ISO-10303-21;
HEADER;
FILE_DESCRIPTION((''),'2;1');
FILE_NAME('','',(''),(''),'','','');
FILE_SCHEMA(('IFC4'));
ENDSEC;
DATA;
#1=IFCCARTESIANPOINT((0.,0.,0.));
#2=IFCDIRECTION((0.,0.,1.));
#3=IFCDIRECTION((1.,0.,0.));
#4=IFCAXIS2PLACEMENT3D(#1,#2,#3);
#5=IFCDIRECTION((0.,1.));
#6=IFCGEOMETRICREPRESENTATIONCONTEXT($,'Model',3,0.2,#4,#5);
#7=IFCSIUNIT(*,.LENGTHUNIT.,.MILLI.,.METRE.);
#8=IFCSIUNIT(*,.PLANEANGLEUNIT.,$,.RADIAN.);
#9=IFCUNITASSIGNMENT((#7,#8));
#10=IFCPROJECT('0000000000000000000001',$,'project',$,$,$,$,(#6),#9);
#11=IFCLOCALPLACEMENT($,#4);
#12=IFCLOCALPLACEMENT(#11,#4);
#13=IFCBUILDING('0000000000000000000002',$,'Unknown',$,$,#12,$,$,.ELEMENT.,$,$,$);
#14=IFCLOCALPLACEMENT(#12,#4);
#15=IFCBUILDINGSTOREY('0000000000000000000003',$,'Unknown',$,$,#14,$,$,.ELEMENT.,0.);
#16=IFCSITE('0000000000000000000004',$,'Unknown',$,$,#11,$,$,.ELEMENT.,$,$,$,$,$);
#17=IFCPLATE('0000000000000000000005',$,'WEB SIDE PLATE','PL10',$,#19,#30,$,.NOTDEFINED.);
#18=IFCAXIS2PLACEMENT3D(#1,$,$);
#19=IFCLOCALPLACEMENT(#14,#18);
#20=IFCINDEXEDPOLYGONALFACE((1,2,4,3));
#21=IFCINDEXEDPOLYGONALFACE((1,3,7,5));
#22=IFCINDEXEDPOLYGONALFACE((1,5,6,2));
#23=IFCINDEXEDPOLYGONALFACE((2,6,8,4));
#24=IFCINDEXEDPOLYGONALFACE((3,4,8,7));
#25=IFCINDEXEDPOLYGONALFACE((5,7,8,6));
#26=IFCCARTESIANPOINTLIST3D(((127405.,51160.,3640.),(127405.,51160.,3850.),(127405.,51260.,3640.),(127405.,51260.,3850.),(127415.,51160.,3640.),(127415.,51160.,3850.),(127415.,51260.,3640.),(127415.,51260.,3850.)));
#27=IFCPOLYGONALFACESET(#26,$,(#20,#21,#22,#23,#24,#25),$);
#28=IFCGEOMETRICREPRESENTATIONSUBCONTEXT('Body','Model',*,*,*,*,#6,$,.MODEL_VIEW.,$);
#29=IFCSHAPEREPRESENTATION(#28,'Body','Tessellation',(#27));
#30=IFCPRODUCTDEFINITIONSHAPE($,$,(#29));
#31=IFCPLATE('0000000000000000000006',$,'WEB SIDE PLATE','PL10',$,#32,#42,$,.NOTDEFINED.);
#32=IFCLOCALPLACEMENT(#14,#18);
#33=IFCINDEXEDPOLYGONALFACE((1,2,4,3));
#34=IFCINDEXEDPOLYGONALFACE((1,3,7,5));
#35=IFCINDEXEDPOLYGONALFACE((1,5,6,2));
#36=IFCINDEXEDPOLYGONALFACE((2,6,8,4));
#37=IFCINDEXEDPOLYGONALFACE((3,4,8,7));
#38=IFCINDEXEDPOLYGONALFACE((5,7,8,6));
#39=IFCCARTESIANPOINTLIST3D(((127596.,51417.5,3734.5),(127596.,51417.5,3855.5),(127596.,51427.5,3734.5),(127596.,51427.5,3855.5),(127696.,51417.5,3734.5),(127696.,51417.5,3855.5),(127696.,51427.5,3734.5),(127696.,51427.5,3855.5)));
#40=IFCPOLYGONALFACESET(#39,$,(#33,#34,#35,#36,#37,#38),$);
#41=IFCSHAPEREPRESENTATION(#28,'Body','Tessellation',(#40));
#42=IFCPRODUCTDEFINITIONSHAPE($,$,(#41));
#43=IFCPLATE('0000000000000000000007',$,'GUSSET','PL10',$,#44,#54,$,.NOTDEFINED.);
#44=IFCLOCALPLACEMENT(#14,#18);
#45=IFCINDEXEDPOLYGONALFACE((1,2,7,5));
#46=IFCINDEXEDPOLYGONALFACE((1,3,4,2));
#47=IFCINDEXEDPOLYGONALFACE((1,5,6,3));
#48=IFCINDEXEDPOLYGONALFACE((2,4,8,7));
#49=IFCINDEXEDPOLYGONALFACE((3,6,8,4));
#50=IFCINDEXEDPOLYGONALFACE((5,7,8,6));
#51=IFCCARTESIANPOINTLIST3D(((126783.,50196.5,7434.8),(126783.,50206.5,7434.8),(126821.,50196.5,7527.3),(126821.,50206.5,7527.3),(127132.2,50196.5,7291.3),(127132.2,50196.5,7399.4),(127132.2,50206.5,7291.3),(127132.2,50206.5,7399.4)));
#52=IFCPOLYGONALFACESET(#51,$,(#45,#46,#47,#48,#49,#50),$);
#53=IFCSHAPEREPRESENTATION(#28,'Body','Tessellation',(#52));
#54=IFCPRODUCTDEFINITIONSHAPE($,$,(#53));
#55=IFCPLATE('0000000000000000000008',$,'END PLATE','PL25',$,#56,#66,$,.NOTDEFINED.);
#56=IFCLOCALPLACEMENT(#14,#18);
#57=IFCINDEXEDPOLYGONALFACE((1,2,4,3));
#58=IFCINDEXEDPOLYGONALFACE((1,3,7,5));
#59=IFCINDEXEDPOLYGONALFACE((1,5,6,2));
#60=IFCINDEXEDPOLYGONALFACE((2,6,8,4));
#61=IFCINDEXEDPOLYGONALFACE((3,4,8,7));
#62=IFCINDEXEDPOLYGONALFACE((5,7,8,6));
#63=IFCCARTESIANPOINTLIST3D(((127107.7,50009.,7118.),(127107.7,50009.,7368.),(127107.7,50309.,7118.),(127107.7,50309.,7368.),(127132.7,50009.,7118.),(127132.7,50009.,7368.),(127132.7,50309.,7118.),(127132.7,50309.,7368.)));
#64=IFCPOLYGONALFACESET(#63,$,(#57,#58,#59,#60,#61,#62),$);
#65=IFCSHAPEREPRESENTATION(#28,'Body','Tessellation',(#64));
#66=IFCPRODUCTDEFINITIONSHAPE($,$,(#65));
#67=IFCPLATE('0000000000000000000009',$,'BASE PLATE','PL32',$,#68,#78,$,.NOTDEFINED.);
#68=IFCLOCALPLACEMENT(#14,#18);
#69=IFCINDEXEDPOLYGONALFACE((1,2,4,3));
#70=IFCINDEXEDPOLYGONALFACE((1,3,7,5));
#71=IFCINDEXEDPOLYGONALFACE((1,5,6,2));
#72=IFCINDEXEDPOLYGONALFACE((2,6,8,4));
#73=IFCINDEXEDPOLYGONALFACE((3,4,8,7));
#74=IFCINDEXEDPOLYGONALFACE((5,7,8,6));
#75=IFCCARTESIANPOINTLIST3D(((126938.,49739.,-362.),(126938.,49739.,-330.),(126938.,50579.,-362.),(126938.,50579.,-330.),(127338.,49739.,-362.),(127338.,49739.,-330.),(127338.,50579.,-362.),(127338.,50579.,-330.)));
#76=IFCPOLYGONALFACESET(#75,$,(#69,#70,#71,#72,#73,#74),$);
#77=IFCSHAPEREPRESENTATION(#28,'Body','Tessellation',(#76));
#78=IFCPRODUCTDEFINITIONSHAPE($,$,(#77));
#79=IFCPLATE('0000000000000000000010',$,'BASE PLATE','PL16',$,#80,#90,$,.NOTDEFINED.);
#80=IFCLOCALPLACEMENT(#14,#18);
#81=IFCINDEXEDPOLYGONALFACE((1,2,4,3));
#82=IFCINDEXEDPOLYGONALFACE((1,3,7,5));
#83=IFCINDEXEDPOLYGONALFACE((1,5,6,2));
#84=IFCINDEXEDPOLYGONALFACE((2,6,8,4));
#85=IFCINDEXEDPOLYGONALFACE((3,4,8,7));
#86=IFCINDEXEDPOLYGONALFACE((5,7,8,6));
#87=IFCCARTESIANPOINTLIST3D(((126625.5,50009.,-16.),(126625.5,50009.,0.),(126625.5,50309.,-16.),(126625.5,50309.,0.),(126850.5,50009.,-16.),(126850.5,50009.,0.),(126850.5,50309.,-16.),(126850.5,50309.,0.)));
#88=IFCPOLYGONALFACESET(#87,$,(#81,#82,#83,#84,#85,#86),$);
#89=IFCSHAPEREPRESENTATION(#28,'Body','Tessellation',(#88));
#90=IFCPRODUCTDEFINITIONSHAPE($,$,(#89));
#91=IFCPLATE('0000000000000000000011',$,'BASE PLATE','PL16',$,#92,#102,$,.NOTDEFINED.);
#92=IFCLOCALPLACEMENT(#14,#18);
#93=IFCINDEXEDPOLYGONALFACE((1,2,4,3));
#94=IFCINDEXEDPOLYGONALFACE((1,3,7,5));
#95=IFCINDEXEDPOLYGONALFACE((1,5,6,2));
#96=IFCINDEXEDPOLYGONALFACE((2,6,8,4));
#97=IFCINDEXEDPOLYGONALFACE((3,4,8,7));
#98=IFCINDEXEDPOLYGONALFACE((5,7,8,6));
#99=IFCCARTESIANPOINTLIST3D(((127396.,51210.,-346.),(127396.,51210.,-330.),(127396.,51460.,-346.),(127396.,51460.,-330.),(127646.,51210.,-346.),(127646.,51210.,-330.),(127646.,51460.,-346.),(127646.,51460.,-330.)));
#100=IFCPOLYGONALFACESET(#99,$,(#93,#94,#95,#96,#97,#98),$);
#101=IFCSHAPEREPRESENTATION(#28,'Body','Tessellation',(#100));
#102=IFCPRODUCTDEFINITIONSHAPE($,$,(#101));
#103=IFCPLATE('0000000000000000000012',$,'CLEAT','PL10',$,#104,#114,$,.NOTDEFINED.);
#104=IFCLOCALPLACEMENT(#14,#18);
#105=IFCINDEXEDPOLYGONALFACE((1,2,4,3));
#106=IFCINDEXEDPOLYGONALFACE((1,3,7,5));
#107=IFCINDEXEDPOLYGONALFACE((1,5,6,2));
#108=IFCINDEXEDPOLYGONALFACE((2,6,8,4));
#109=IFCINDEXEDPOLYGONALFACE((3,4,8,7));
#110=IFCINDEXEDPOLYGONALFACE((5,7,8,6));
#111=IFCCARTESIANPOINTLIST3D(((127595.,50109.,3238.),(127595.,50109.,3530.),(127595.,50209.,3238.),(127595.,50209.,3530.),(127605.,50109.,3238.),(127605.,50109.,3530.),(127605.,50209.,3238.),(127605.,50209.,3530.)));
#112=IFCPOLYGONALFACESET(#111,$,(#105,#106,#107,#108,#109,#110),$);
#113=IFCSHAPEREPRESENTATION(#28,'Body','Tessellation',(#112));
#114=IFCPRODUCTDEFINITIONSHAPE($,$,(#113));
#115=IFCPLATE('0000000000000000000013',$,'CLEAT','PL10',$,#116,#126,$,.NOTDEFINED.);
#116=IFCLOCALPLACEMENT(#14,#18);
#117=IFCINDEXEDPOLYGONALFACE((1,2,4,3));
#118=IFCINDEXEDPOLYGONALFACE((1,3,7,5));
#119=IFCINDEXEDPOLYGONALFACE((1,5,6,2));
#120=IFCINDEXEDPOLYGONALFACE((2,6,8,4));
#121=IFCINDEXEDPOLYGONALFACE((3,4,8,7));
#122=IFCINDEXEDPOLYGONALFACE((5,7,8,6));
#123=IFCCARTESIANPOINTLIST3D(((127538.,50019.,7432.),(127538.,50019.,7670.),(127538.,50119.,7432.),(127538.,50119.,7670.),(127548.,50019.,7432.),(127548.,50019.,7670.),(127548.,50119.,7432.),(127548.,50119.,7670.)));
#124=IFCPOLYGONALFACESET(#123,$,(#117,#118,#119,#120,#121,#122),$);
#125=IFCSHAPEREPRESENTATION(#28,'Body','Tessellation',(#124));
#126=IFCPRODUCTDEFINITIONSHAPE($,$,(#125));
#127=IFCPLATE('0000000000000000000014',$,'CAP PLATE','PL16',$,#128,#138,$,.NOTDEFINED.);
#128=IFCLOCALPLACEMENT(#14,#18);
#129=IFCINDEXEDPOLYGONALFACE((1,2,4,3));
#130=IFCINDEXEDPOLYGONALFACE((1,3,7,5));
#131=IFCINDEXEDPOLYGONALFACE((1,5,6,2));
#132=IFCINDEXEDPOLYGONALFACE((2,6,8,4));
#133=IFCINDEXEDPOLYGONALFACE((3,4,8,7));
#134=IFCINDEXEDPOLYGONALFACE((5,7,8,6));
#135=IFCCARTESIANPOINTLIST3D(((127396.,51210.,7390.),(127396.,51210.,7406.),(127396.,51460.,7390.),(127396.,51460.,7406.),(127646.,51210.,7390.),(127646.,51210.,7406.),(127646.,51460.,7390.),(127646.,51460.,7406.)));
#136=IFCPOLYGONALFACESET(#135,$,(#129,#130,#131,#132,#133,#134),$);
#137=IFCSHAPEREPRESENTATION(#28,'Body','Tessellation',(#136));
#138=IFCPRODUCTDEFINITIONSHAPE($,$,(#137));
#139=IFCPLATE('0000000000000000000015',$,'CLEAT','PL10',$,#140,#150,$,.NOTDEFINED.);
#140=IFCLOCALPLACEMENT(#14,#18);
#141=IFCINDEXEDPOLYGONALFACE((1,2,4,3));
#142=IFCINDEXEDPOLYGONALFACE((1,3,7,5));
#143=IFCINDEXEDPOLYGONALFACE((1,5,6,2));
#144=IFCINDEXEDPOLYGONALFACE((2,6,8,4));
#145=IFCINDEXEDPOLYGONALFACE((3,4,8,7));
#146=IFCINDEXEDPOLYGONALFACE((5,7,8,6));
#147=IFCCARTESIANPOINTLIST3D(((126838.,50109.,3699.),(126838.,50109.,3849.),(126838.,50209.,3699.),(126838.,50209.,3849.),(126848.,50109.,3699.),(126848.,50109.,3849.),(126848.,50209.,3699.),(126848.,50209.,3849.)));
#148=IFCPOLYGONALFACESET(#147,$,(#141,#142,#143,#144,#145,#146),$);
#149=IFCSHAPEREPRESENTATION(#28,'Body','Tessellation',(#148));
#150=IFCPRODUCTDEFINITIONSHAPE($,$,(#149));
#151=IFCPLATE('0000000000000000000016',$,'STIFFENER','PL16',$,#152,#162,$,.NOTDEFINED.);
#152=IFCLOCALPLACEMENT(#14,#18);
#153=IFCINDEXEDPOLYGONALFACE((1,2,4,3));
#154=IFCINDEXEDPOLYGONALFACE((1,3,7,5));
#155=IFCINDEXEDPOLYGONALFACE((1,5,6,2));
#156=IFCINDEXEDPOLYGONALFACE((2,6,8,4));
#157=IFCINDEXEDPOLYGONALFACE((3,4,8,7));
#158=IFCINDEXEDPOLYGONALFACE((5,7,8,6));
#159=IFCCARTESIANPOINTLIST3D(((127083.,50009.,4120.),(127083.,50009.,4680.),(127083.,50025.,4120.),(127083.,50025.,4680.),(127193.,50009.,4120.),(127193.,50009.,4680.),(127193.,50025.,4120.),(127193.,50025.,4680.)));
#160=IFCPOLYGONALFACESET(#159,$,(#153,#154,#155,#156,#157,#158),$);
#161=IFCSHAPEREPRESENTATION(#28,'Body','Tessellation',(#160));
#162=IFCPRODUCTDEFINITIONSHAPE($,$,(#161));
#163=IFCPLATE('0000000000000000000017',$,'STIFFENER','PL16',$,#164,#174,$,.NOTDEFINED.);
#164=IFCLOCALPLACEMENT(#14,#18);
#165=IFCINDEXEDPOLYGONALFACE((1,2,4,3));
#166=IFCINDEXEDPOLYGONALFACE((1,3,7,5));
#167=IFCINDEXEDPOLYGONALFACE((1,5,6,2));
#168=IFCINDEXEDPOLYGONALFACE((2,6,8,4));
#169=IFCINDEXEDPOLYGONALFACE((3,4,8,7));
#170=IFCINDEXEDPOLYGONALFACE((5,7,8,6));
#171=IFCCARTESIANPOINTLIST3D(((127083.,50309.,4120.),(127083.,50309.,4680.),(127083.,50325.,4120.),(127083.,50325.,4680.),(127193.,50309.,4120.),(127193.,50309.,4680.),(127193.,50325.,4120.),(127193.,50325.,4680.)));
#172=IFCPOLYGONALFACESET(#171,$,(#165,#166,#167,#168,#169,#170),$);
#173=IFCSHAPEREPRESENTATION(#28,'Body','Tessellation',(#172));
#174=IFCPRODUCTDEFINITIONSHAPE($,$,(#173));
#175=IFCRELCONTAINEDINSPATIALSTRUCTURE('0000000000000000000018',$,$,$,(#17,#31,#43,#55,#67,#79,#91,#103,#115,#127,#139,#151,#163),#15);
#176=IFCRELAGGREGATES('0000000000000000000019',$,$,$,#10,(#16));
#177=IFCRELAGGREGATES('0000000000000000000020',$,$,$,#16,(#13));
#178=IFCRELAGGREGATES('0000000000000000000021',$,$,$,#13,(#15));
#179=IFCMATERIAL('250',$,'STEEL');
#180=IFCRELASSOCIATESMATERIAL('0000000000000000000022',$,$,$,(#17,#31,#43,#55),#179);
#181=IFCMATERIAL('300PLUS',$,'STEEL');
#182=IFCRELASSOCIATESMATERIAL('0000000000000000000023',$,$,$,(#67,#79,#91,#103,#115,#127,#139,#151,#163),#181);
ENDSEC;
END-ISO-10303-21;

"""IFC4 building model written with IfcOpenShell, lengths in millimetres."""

from ifc_helpers import new_model, si_unit, direction, frame, origin_with_axes, place, context, subcontext, project, spatial, line, indexed_curve, outline, extrude, material, element, save


model = new_model("IFC4")

# Units and contexts
model_context = context("Model", 3, precision=0.2, world=origin_with_axes(), true_north=direction((0.0, 1.0)))
body_context = subcontext(model_context, "Body", "Model", "MODEL_VIEW")
ifc_project = project(units=[si_unit("LENGTHUNIT", "METRE", prefix="MILLI"), si_unit("PLANEANGLEUNIT", "RADIAN")], contexts=[model_context])

# Site, building, storey
site_placement = place(None, origin_with_axes())
site = spatial("IfcSite", under=ifc_project, at=site_placement, Name="Unknown", CompositionType="ELEMENT")
building_placement = place(site_placement, origin_with_axes())
building = spatial("IfcBuilding", under=site, at=building_placement, Name="Unknown", CompositionType="ELEMENT")
storey_placement = place(building_placement, origin_with_axes())
storey = spatial("IfcBuildingStorey", under=building, at=storey_placement, Name="Unknown", CompositionType="ELEMENT", Elevation=0.0)

# Shared definitions
ifc_material_1 = material(Name="300PLUS", Category="STEEL")

# Plates
ifc_material_2 = material(Name="250", Category="STEEL")
plate_1_placement = place(storey_placement, frame((127410.0, 51260.0, 3640.0), z_axis=(-1.0, 0.0, 0.0), x_axis=(0.0, -1.0, 0.0)))
element("IfcPlate", 1, at=plate_1_placement, inside=storey, material=ifc_material_2, Name="WEB SIDE PLATE", Description="PL10", PredefinedType="NOTDEFINED", context=body_context, shape_type="SolidModel", body=[
    extrude(outline(indexed_curve([(0.0, 0.0), (100.0, 0.0), (100.0, 210.0), (0.0, 210.0)], segments=[line(1, 2, 3, 4, 1)])), frame((0.0, 0.0, 5.0), z_axis=(0.0, 0.0, 1.0), x_axis=(1.0, 0.0, 0.0)), (0.0, 0.0, -1.0), 10.0),
])
plate_2_placement = place(storey_placement, frame((127596.0, 51422.5, 3855.5), z_axis=(0.0, 1.0, 0.0), x_axis=(1.0, 0.0, 0.0)))
element("IfcPlate", 2, at=plate_2_placement, inside=storey, material=ifc_material_2, Name="WEB SIDE PLATE", Description="PL10", PredefinedType="NOTDEFINED", context=body_context, shape_type="SolidModel", body=[
    extrude(outline(indexed_curve([(0.0, 0.0), (100.0, 0.0), (100.0, 121.0), (0.0, 121.0)], segments=[line(1, 2, 3, 4, 1)])), frame((0.0, 0.0, 5.0), z_axis=(0.0, 0.0, 1.0), x_axis=(1.0, 0.0, 0.0)), (0.0, 0.0, -1.0), 10.0),
])
plate_3_placement = place(storey_placement, frame((127132.2, 50201.5, 7291.3), z_axis=(0.0, 1.0, 0.0), x_axis=(-0.924947, 0.0, 0.380097)))
element("IfcPlate", 3, at=plate_3_placement, inside=storey, material=ifc_material_2, Name="GUSSET", Description="PL10", PredefinedType="NOTDEFINED", context=body_context, shape_type="SolidModel", body=[
    extrude(outline(indexed_curve([(0.0, 0.0), (377.5, 0.0), (377.5, 100.0), (41.1, 100.0)], segments=[line(1, 2, 3, 4, 1)])), frame((0.0, 0.0, 5.0), z_axis=(0.0, 0.0, 1.0), x_axis=(1.0, 0.0, 0.0)), (0.0, 0.0, -1.0), 10.0),
])
plate_4_placement = place(storey_placement, frame((127120.2, 50009.0, 7118.0), z_axis=(-1.0, 0.0, 0.0), x_axis=(0.0, 0.0, 1.0)))
element("IfcPlate", 4, at=plate_4_placement, inside=storey, material=ifc_material_2, Name="END PLATE", Description="PL25", PredefinedType="NOTDEFINED", context=body_context, shape_type="SolidModel", body=[
    extrude(outline(indexed_curve([(0.0, 0.0), (250.0, 0.0), (250.0, 300.0), (0.0, 300.0)], segments=[line(1, 2, 3, 4, 1)])), frame((0.0, 0.0, 12.5), z_axis=(0.0, 0.0, 1.0), x_axis=(1.0, 0.0, 0.0)), (0.0, 0.0, -1.0), 25.0),
])
plate_5_placement = place(storey_placement, frame((127338.0, 49739.0, -346.0), z_axis=(0.0, 0.0, 1.0), x_axis=(0.0, 1.0, 0.0)))
element("IfcPlate", 5, at=plate_5_placement, inside=storey, material=ifc_material_1, Name="BASE PLATE", Description="PL32", PredefinedType="NOTDEFINED", context=body_context, shape_type="SolidModel", body=[
    extrude(outline(indexed_curve([(0.0, 0.0), (840.0, 0.0), (840.0, 400.0), (0.0, 400.0)], segments=[line(1, 2, 3, 4, 1)])), frame((0.0, 0.0, 16.0), z_axis=(0.0, 0.0, 1.0), x_axis=(1.0, 0.0, 0.0)), (0.0, 0.0, -1.0), 32.0),
])
plate_6_placement = place(storey_placement, frame((126625.5, 50009.0, -8.0), z_axis=(0.0, 0.0, 1.0), x_axis=(1.0, 0.0, 0.0)))
element("IfcPlate", 6, at=plate_6_placement, inside=storey, material=ifc_material_1, Name="BASE PLATE", Description="PL16", PredefinedType="NOTDEFINED", context=body_context, shape_type="SolidModel", body=[
    extrude(outline(indexed_curve([(0.0, 0.0), (225.0, 0.0), (225.0, 300.0), (0.0, 300.0)], segments=[line(1, 2, 3, 4, 1)])), frame((0.0, 0.0, 8.0), z_axis=(0.0, 0.0, 1.0), x_axis=(1.0, 0.0, 0.0)), (0.0, 0.0, -1.0), 16.0),
])
plate_7_placement = place(storey_placement, frame((127396.0, 51210.0, -338.0), z_axis=(0.0, 0.0, 1.0), x_axis=(1.0, 0.0, 0.0)))
element("IfcPlate", 7, at=plate_7_placement, inside=storey, material=ifc_material_1, Name="BASE PLATE", Description="PL16", PredefinedType="NOTDEFINED", context=body_context, shape_type="SolidModel", body=[
    extrude(outline(indexed_curve([(0.0, 0.0), (250.0, 0.0), (250.0, 250.0), (0.0, 250.0)], segments=[line(1, 2, 3, 4, 1)])), frame((0.0, 0.0, 8.0), z_axis=(0.0, 0.0, 1.0), x_axis=(1.0, 0.0, 0.0)), (0.0, 0.0, -1.0), 16.0),
])
plate_8_placement = place(storey_placement, frame((127600.0, 50109.0, 3238.0), z_axis=(1.0, 0.0, 0.0), x_axis=(0.0, 1.0, 0.0)))
element("IfcPlate", 8, at=plate_8_placement, inside=storey, material=ifc_material_1, Name="CLEAT", Description="PL10", PredefinedType="NOTDEFINED", context=body_context, shape_type="SolidModel", body=[
    extrude(outline(indexed_curve([(0.0, 0.0), (100.0, 0.0), (100.0, 292.0), (0.0, 292.0)], segments=[line(1, 2, 3, 4, 1)])), frame((0.0, 0.0, 5.0), z_axis=(0.0, 0.0, 1.0), x_axis=(1.0, 0.0, 0.0)), (0.0, 0.0, -1.0), 10.0),
])
plate_9_placement = place(storey_placement, frame((127543.0, 50019.0, 7432.0), z_axis=(1.0, 0.0, 0.0), x_axis=(0.0, 1.0, 0.0)))
element("IfcPlate", 9, at=plate_9_placement, inside=storey, material=ifc_material_1, Name="CLEAT", Description="PL10", PredefinedType="NOTDEFINED", context=body_context, shape_type="SolidModel", body=[
    extrude(outline(indexed_curve([(0.0, 0.0), (100.0, 0.0), (100.0, 238.0), (0.0, 238.0)], segments=[line(1, 2, 3, 4, 1)])), frame((0.0, 0.0, 5.0), z_axis=(0.0, 0.0, 1.0), x_axis=(1.0, 0.0, 0.0)), (0.0, 0.0, -1.0), 10.0),
])
plate_10_placement = place(storey_placement, frame((127396.0, 51210.0, 7398.0), z_axis=(0.0, 0.0, 1.0), x_axis=(1.0, 0.0, 0.0)))
element("IfcPlate", 10, at=plate_10_placement, inside=storey, material=ifc_material_1, Name="CAP PLATE", Description="PL16", PredefinedType="NOTDEFINED", context=body_context, shape_type="SolidModel", body=[
    extrude(outline(indexed_curve([(0.0, 0.0), (250.0, 0.0), (250.0, 250.0), (0.0, 250.0)], segments=[line(1, 2, 3, 4, 1)])), frame((0.0, 0.0, 8.0), z_axis=(0.0, 0.0, 1.0), x_axis=(1.0, 0.0, 0.0)), (0.0, 0.0, -1.0), 16.0),
])
plate_11_placement = place(storey_placement, frame((126843.0, 50109.0, 3699.0), z_axis=(1.0, 0.0, 0.0), x_axis=(0.0, 1.0, 0.0)))
element("IfcPlate", 11, at=plate_11_placement, inside=storey, material=ifc_material_1, Name="CLEAT", Description="PL10", PredefinedType="NOTDEFINED", context=body_context, shape_type="SolidModel", body=[
    extrude(outline(indexed_curve([(0.0, 0.0), (100.0, 0.0), (100.0, 150.0), (0.0, 150.0)], segments=[line(1, 2, 3, 4, 1)])), frame((0.0, 0.0, 5.0), z_axis=(0.0, 0.0, 1.0), x_axis=(1.0, 0.0, 0.0)), (0.0, 0.0, -1.0), 10.0),
])
for number, where, z_axis, x_axis, name in (
    (12, (127083.0, 50017.0, 4120.0), (0.0, -1.0, 0.0), (1.0, 0.0, 0.0), "STIFFENER"),
    (13, (127083.0, 50317.0, 4120.0), (0.0, -1.0, 0.0), (1.0, 0.0, 0.0), "STIFFENER"),
):
    element("IfcPlate", number, at=place(storey_placement, frame(where, z_axis=z_axis, x_axis=x_axis)), inside=storey, material=ifc_material_1, Name=name, Description="PL16", PredefinedType="NOTDEFINED", context=body_context, shape_type="SolidModel", body=[
        extrude(outline(indexed_curve([(0.0, 0.0), (110.0, 0.0), (110.0, 560.0), (0.0, 560.0)], segments=[line(1, 2, 3, 4, 1)])), frame((0.0, 0.0, 8.0), z_axis=(0.0, 0.0, 1.0), x_axis=(1.0, 0.0, 0.0)), (0.0, 0.0, -1.0), 16.0),
    ])

save(model, "model.ifc")
